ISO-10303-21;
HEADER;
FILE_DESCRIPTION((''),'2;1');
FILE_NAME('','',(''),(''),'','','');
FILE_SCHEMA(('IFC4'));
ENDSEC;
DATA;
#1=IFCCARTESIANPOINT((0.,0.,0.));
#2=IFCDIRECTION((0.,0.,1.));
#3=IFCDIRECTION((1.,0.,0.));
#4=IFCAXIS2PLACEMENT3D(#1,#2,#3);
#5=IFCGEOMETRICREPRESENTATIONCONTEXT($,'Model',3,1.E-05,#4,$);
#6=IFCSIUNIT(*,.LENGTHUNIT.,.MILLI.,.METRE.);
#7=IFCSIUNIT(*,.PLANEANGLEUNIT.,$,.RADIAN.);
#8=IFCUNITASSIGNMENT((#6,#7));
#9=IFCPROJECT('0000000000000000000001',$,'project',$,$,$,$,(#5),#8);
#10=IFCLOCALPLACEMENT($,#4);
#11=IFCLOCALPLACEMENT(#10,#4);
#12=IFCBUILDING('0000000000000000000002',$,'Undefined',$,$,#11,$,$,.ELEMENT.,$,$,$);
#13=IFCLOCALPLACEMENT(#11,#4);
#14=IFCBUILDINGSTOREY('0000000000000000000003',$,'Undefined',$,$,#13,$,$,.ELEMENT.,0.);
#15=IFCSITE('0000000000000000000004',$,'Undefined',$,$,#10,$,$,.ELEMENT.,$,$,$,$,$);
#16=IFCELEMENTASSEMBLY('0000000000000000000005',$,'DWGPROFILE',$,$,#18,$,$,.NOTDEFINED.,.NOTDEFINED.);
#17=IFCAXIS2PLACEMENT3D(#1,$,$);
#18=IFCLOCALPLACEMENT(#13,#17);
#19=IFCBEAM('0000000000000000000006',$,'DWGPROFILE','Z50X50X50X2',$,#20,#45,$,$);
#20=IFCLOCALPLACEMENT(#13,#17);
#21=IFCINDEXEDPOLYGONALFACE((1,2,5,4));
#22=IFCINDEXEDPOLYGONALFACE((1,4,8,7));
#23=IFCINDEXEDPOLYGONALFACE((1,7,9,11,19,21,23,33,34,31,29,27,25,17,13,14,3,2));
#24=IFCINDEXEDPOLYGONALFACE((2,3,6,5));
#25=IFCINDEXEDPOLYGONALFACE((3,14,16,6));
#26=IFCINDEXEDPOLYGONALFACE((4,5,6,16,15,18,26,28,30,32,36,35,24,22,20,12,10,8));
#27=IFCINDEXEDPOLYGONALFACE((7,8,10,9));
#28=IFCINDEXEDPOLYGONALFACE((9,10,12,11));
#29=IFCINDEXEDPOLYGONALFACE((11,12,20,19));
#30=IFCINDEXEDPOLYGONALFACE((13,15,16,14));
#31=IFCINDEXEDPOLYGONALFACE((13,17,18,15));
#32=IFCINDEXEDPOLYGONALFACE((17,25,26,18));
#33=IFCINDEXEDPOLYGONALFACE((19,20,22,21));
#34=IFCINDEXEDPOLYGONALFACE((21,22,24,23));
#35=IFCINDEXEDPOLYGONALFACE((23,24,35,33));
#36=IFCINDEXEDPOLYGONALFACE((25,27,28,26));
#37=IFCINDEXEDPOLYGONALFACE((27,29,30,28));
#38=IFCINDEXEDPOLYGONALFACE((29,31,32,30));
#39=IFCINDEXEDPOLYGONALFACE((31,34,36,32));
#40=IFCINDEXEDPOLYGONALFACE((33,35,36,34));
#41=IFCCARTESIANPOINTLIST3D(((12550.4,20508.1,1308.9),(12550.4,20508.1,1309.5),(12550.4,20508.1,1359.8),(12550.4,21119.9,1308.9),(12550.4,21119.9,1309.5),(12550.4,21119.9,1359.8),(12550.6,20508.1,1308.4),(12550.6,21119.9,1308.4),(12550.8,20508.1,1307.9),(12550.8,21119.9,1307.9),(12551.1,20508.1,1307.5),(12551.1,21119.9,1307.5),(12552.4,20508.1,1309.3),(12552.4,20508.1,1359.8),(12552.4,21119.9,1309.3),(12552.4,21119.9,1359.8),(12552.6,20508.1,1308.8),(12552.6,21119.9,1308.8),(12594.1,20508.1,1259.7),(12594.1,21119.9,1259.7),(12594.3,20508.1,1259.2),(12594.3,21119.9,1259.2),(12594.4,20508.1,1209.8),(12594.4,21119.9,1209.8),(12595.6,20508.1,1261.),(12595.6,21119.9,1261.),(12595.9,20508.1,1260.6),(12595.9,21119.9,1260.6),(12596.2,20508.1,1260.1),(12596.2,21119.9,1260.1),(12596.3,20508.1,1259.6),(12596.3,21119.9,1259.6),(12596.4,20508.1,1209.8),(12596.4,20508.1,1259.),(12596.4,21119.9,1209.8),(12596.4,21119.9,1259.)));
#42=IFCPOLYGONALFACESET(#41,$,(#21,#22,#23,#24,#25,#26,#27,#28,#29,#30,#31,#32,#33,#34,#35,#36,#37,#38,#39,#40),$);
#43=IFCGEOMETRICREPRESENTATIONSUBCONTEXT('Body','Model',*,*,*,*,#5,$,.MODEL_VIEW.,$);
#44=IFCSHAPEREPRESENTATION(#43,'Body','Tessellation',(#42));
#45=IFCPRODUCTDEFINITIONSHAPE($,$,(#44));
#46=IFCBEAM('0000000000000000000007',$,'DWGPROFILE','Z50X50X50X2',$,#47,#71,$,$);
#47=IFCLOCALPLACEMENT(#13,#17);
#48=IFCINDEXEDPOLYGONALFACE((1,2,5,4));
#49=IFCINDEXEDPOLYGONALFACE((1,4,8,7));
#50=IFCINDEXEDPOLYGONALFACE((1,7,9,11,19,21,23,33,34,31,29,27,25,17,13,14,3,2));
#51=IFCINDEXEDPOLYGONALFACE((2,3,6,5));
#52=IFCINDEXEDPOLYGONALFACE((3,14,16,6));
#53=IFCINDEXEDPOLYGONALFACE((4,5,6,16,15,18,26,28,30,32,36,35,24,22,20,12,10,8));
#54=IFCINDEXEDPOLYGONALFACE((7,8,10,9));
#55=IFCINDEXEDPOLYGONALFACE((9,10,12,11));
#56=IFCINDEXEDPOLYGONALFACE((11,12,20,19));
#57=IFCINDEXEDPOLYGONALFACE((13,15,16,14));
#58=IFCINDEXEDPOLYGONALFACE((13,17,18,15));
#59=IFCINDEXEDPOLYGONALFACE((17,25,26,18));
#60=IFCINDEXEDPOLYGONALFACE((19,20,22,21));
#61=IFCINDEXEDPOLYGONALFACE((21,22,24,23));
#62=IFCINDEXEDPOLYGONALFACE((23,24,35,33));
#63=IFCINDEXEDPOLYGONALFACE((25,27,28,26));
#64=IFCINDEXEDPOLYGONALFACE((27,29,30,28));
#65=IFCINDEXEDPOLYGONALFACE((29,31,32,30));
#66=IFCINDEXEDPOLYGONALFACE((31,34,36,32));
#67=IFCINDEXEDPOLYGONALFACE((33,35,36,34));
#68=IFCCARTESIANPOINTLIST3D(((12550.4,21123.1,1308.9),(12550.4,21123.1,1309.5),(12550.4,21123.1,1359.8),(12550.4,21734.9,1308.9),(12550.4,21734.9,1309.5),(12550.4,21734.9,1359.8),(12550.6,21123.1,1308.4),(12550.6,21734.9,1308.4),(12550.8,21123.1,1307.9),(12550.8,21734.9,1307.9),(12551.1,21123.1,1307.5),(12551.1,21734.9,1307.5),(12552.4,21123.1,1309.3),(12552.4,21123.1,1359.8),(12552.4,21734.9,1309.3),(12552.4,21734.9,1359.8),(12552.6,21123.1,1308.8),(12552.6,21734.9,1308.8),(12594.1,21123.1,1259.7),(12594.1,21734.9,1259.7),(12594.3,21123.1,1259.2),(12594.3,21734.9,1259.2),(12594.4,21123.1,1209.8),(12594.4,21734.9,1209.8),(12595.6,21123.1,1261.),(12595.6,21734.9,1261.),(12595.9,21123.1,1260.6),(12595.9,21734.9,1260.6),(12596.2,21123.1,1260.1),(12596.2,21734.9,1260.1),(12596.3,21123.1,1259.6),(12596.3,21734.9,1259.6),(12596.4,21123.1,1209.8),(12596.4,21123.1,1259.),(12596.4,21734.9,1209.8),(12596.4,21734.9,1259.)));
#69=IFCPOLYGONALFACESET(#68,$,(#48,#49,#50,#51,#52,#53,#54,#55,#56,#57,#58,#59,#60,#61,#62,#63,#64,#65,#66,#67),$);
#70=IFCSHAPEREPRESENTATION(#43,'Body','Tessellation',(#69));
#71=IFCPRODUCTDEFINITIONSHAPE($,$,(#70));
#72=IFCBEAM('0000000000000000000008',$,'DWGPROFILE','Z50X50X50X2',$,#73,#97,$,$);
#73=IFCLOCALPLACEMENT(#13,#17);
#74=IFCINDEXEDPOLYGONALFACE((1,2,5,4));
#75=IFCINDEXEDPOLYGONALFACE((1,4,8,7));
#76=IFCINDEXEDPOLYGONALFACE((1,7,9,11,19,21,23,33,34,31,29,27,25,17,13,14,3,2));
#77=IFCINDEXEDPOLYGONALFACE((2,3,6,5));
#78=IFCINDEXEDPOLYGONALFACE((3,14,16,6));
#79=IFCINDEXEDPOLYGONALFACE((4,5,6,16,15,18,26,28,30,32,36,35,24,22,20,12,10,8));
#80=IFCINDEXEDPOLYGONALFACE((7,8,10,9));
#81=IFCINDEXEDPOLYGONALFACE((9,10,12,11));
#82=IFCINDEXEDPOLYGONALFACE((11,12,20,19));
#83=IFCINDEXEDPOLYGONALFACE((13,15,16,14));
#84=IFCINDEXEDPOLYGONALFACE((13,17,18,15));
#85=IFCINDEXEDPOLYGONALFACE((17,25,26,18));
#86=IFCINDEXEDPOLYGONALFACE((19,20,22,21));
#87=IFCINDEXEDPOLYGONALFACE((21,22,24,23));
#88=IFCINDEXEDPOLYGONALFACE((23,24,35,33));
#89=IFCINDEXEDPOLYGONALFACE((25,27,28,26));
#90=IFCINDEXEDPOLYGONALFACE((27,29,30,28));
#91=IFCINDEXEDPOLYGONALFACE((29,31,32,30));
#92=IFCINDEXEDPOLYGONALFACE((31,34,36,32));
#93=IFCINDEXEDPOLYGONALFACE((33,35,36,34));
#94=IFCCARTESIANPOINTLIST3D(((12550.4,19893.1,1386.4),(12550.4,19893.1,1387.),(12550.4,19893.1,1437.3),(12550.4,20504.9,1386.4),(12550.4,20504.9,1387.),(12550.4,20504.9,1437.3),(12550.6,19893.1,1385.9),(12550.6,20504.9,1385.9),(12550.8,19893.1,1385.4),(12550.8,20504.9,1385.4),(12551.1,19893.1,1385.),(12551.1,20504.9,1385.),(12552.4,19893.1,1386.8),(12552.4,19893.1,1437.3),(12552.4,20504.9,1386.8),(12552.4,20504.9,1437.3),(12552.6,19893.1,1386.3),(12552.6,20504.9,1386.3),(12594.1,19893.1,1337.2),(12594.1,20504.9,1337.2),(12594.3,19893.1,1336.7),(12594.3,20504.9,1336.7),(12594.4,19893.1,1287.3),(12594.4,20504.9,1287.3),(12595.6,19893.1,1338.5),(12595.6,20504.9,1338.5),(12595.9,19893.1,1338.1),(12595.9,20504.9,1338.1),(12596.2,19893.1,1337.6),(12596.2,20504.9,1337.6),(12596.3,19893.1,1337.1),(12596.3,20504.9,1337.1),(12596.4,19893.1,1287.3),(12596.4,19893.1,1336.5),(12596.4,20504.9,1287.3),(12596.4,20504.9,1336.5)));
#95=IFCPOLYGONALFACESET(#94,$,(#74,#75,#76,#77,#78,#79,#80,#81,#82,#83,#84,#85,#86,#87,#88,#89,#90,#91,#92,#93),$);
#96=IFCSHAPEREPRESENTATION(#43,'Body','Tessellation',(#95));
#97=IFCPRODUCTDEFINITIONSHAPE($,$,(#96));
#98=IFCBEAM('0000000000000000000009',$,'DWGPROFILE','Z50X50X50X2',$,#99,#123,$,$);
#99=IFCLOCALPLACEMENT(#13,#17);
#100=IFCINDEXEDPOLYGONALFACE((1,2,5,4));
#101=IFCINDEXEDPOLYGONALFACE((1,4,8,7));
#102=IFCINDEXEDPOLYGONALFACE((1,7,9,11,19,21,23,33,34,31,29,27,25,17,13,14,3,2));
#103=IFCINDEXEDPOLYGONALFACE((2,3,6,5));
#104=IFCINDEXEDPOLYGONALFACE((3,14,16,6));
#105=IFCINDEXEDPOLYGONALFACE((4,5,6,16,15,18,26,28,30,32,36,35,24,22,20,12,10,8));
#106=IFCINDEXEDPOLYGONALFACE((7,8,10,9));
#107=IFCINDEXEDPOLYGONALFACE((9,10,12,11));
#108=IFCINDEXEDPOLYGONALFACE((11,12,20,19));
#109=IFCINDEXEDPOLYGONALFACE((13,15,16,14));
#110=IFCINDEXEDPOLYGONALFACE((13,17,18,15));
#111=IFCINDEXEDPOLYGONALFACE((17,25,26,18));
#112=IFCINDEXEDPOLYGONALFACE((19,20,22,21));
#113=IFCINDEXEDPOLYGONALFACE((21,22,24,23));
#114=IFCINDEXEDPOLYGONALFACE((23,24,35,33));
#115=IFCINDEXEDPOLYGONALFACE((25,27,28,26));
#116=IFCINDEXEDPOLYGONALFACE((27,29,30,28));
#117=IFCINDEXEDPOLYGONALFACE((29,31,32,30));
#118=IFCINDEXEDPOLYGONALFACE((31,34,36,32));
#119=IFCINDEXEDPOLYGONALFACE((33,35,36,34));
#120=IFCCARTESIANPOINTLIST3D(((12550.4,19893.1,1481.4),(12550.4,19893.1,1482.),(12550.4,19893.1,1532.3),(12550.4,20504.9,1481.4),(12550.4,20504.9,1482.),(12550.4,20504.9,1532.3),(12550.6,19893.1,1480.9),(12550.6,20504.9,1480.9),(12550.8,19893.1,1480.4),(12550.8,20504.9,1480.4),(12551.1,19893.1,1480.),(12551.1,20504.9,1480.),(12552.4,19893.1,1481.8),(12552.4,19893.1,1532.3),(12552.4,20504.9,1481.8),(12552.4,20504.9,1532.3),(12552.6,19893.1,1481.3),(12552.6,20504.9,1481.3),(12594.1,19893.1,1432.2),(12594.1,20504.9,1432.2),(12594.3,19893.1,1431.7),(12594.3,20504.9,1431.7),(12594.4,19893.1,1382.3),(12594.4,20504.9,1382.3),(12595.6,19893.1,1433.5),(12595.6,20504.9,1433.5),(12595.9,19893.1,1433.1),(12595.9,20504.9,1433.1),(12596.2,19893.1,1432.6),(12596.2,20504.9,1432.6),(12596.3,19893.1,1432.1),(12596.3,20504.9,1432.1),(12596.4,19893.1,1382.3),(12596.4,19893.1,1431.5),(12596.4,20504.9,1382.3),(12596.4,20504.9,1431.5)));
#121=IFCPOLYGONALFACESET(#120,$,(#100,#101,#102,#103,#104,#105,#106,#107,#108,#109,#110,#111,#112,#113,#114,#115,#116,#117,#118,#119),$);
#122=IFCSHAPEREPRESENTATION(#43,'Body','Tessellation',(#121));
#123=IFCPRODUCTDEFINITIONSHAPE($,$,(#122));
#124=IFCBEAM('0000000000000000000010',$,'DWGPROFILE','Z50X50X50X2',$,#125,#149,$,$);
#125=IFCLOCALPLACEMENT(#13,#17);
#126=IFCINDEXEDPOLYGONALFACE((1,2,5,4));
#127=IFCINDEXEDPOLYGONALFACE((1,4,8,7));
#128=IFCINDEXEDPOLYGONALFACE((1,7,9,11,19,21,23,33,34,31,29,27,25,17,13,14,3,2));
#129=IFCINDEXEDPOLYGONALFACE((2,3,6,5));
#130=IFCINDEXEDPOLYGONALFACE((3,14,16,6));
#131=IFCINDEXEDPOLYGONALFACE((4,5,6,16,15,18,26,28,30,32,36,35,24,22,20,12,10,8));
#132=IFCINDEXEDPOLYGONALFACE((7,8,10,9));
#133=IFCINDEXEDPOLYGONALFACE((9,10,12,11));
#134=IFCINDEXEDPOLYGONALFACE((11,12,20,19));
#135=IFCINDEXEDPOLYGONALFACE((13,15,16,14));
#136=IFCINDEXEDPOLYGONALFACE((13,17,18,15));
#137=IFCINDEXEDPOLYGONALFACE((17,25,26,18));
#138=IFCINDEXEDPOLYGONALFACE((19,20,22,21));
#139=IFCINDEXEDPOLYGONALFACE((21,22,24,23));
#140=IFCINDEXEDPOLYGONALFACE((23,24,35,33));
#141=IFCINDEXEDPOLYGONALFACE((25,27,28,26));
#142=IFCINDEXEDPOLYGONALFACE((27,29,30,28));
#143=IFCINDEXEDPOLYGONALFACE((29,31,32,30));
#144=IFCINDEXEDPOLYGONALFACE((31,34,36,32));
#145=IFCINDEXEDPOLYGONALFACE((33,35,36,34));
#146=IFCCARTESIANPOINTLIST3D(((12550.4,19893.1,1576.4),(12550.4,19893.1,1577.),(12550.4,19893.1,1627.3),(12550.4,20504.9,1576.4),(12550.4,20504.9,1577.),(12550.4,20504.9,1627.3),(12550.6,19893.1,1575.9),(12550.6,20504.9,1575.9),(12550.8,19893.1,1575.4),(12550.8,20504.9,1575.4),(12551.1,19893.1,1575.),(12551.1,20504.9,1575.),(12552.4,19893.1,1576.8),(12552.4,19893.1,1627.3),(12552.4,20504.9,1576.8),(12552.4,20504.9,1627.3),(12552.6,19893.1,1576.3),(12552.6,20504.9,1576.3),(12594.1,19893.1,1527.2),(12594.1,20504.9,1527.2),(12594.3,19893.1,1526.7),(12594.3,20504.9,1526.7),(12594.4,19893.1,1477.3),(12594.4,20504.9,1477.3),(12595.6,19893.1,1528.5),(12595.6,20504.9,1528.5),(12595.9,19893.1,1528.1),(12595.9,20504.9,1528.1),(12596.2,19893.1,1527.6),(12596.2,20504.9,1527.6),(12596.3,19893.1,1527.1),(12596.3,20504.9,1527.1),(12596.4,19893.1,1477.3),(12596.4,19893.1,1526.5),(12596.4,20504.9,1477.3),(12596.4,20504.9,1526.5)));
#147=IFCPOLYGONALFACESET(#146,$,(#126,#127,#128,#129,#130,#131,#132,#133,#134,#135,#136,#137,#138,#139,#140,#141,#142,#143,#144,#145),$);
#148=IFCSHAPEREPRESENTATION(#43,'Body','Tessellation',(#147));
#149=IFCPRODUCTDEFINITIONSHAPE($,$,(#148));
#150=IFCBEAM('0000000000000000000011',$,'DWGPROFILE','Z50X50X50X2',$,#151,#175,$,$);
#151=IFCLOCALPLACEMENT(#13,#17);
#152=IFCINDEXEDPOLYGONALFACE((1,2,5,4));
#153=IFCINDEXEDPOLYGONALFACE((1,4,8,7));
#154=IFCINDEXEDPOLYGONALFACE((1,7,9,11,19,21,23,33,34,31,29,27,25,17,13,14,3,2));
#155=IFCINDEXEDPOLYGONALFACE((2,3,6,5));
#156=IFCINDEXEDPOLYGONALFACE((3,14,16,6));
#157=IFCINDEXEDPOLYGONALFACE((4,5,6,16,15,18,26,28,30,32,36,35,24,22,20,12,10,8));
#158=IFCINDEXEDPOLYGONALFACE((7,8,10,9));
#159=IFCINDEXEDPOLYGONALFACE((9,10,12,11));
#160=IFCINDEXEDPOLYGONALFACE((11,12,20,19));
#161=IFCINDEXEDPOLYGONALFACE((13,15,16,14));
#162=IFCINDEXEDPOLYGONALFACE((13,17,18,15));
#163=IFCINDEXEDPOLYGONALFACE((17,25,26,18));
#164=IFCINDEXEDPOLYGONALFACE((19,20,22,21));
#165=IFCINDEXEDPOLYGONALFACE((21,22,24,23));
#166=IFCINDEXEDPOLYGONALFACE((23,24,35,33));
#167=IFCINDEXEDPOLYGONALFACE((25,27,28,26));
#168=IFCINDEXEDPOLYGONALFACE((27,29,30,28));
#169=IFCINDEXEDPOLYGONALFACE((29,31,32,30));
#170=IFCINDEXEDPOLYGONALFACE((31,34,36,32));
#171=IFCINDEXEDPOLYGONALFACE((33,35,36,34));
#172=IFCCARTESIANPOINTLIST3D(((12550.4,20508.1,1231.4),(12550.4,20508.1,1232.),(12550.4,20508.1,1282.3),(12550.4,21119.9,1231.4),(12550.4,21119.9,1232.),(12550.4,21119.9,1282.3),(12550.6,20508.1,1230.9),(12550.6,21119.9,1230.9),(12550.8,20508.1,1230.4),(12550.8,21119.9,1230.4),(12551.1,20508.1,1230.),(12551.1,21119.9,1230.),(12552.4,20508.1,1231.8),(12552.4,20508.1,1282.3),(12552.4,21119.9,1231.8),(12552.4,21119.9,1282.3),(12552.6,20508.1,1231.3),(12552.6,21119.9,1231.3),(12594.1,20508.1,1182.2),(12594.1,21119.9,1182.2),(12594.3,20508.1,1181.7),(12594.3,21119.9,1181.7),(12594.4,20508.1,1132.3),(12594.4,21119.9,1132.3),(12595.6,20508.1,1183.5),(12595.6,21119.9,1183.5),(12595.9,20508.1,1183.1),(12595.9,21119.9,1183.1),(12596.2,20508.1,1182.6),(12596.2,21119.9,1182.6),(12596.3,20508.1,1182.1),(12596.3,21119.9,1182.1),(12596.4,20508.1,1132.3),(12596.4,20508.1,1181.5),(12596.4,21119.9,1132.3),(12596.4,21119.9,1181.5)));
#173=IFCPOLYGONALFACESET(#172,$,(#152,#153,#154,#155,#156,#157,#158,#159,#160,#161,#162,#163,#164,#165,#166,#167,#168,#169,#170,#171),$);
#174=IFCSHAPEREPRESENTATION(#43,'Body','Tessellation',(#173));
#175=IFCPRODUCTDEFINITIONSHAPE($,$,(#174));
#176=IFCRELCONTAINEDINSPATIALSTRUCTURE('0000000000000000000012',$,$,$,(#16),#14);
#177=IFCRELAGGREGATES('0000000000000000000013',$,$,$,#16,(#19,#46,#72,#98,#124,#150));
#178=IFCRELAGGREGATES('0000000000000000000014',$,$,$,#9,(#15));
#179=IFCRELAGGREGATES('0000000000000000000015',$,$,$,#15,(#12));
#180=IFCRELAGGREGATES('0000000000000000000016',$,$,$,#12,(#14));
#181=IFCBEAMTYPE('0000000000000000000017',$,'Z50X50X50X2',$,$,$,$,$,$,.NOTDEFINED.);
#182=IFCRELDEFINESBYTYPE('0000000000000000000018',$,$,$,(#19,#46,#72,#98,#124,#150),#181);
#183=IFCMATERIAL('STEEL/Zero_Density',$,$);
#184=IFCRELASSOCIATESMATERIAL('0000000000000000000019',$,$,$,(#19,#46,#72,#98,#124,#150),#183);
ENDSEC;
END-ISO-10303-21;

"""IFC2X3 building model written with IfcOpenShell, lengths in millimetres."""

from ifc_helpers import new_model, si_unit, frame, origin_with_axes, place, context, subcontext, project, spatial, polyline, outline, extrude, material, type_object, element, aggregate, save


model = new_model("IFC2X3")

# Units and contexts
model_context = context("Model", 3, precision=1e-05, world=origin_with_axes())
body_context = subcontext(model_context, "Body", "Model", "MODEL_VIEW")
ifc_project = project(units=[si_unit("LENGTHUNIT", "METRE", prefix="MILLI"), si_unit("PLANEANGLEUNIT", "RADIAN")], contexts=[model_context])

# Site, building, storey
site_placement = place(None, origin_with_axes())
site = spatial("IfcSite", under=ifc_project, at=site_placement, Name="Undefined", CompositionType="ELEMENT")
building_placement = place(site_placement, origin_with_axes())
building = spatial("IfcBuilding", under=site, at=building_placement, Name="Undefined", CompositionType="ELEMENT")
storey_placement = place(building_placement, origin_with_axes())
storey = spatial("IfcBuildingStorey", under=building, at=storey_placement, Name="Undefined", CompositionType="ELEMENT", Elevation=0.0)

# Element assembly, beams
assembly_1_placement = place(storey_placement, origin_with_axes())
assembly_1 = element("IfcElementAssembly", 1, at=assembly_1_placement, inside=storey, Name="DWGPROFILE", AssemblyPlace="NOTDEFINED", PredefinedType="NOTDEFINED")
ifc_material_1 = material(Name="STEEL/Zero_Density")
beam_type_1 = type_object("IfcBeamType", Name="Z50X50X50X2", PredefinedType="NOTDEFINED")
beam_1_placement = place(assembly_1_placement, frame((12573.4, 20508.1, 1284.8), z_axis=(0.0, 0.0, 1.0), x_axis=(0.0, 1.0, 0.0)))
beam_1 = element("IfcBeam", 2, at=beam_1_placement, type_object=beam_type_1, material=ifc_material_1, Name="DWGPROFILE", Description="Z50X50X50X2", context=body_context, shape_type="SweptSolid", body=[
    extrude(outline(polyline([(-22.9, 24.1), (-23.0, 24.7), (-23.0, 75.0), (-21.0, 75.0), (-21.0, 24.5), (-20.7, 24.0), (22.2, -23.8), (22.6, -24.2), (22.8, -24.7), (22.9, -25.2), (23.0, -25.8), (23.0, -75.0), (21.0, -75.0), (21.0, -25.6), (20.7, -25.1), (-22.2, 22.6), (-22.6, 23.1), (-22.8, 23.6), (-22.9, 24.1)])), frame((611.8, 0.0, 0.0), z_axis=(-1.0, 0.0, 0.0), x_axis=(0.0, -1.0, 0.0)), (0.0, 0.0, 1.0), 611.8),
])
beam_2_placement = place(assembly_1_placement, frame((12573.4, 21123.1, 1284.8), z_axis=(0.0, 0.0, 1.0), x_axis=(0.0, 1.0, 0.0)))
beam_2 = element("IfcBeam", 3, at=beam_2_placement, type_object=beam_type_1, material=ifc_material_1, Name="DWGPROFILE", Description="Z50X50X50X2", context=body_context, shape_type="SweptSolid", body=[
    extrude(outline(polyline([(-22.9, 24.1), (-23.0, 24.7), (-23.0, 75.0), (-21.0, 75.0), (-21.0, 24.5), (-20.7, 24.0), (22.2, -23.8), (22.6, -24.2), (22.8, -24.7), (22.9, -25.2), (23.0, -25.8), (23.0, -75.0), (21.0, -75.0), (21.0, -25.6), (20.7, -25.1), (-22.2, 22.6), (-22.6, 23.1), (-22.8, 23.6), (-22.9, 24.1)])), frame((611.8, 0.0, 0.0), z_axis=(-1.0, 0.0, 0.0), x_axis=(0.0, -1.0, 0.0)), (0.0, 0.0, 1.0), 611.8),
])
beam_3_placement = place(assembly_1_placement, frame((12573.4, 19893.1, 1362.3), z_axis=(0.0, 0.0, 1.0), x_axis=(0.0, 1.0, 0.0)))
beam_3 = element("IfcBeam", 4, at=beam_3_placement, type_object=beam_type_1, material=ifc_material_1, Name="DWGPROFILE", Description="Z50X50X50X2", context=body_context, shape_type="SweptSolid", body=[
    extrude(outline(polyline([(-22.9, 24.1), (-23.0, 24.7), (-23.0, 75.0), (-21.0, 75.0), (-21.0, 24.5), (-20.7, 24.0), (22.2, -23.8), (22.6, -24.2), (22.8, -24.7), (22.9, -25.2), (23.0, -25.8), (23.0, -75.0), (21.0, -75.0), (21.0, -25.6), (20.7, -25.1), (-22.2, 22.6), (-22.6, 23.1), (-22.8, 23.6), (-22.9, 24.1)])), frame((611.8, 0.0, 0.0), z_axis=(-1.0, 0.0, 0.0), x_axis=(0.0, -1.0, 0.0)), (0.0, 0.0, 1.0), 611.8),
])
beam_4_placement = place(assembly_1_placement, frame((12573.4, 19893.1, 1457.3), z_axis=(0.0, 0.0, 1.0), x_axis=(0.0, 1.0, 0.0)))
beam_4 = element("IfcBeam", 5, at=beam_4_placement, type_object=beam_type_1, material=ifc_material_1, Name="DWGPROFILE", Description="Z50X50X50X2", context=body_context, shape_type="SweptSolid", body=[
    extrude(outline(polyline([(-22.9, 24.1), (-23.0, 24.7), (-23.0, 75.0), (-21.0, 75.0), (-21.0, 24.5), (-20.7, 24.0), (22.2, -23.8), (22.6, -24.2), (22.8, -24.7), (22.9, -25.2), (23.0, -25.8), (23.0, -75.0), (21.0, -75.0), (21.0, -25.6), (20.7, -25.1), (-22.2, 22.6), (-22.6, 23.1), (-22.8, 23.6), (-22.9, 24.1)])), frame((611.8, 0.0, 0.0), z_axis=(-1.0, 0.0, 0.0), x_axis=(0.0, -1.0, 0.0)), (0.0, 0.0, 1.0), 611.8),
])
beam_5_placement = place(assembly_1_placement, frame((12573.4, 19893.1, 1552.3), z_axis=(0.0, 0.0, 1.0), x_axis=(0.0, 1.0, 0.0)))
beam_5 = element("IfcBeam", 6, at=beam_5_placement, type_object=beam_type_1, material=ifc_material_1, Name="DWGPROFILE", Description="Z50X50X50X2", context=body_context, shape_type="SweptSolid", body=[
    extrude(outline(polyline([(-22.9, 24.1), (-23.0, 24.7), (-23.0, 75.0), (-21.0, 75.0), (-21.0, 24.5), (-20.7, 24.0), (22.2, -23.8), (22.6, -24.2), (22.8, -24.7), (22.9, -25.2), (23.0, -25.8), (23.0, -75.0), (21.0, -75.0), (21.0, -25.6), (20.7, -25.1), (-22.2, 22.6), (-22.6, 23.1), (-22.8, 23.6), (-22.9, 24.1)])), frame((611.8, 0.0, 0.0), z_axis=(-1.0, 0.0, 0.0), x_axis=(0.0, -1.0, 0.0)), (0.0, 0.0, 1.0), 611.8),
])
beam_6_placement = place(assembly_1_placement, frame((12573.4, 20508.1, 1207.3), z_axis=(0.0, 0.0, 1.0), x_axis=(0.0, 1.0, 0.0)))
beam_6 = element("IfcBeam", 7, at=beam_6_placement, type_object=beam_type_1, material=ifc_material_1, Name="DWGPROFILE", Description="Z50X50X50X2", context=body_context, shape_type="SweptSolid", body=[
    extrude(outline(polyline([(-22.9, 24.1), (-23.0, 24.7), (-23.0, 75.0), (-21.0, 75.0), (-21.0, 24.5), (-20.7, 24.0), (22.2, -23.8), (22.6, -24.2), (22.8, -24.7), (22.9, -25.2), (23.0, -25.8), (23.0, -75.0), (21.0, -75.0), (21.0, -25.6), (20.7, -25.1), (-22.2, 22.6), (-22.6, 23.1), (-22.8, 23.6), (-22.9, 24.1)])), frame((611.8, 0.0, 0.0), z_axis=(-1.0, 0.0, 0.0), x_axis=(0.0, -1.0, 0.0)), (0.0, 0.0, 1.0), 611.8),
])

aggregate(assembly_1, [beam_1, beam_2, beam_3, beam_4, beam_5, beam_6])

save(model, "model.ifc")
